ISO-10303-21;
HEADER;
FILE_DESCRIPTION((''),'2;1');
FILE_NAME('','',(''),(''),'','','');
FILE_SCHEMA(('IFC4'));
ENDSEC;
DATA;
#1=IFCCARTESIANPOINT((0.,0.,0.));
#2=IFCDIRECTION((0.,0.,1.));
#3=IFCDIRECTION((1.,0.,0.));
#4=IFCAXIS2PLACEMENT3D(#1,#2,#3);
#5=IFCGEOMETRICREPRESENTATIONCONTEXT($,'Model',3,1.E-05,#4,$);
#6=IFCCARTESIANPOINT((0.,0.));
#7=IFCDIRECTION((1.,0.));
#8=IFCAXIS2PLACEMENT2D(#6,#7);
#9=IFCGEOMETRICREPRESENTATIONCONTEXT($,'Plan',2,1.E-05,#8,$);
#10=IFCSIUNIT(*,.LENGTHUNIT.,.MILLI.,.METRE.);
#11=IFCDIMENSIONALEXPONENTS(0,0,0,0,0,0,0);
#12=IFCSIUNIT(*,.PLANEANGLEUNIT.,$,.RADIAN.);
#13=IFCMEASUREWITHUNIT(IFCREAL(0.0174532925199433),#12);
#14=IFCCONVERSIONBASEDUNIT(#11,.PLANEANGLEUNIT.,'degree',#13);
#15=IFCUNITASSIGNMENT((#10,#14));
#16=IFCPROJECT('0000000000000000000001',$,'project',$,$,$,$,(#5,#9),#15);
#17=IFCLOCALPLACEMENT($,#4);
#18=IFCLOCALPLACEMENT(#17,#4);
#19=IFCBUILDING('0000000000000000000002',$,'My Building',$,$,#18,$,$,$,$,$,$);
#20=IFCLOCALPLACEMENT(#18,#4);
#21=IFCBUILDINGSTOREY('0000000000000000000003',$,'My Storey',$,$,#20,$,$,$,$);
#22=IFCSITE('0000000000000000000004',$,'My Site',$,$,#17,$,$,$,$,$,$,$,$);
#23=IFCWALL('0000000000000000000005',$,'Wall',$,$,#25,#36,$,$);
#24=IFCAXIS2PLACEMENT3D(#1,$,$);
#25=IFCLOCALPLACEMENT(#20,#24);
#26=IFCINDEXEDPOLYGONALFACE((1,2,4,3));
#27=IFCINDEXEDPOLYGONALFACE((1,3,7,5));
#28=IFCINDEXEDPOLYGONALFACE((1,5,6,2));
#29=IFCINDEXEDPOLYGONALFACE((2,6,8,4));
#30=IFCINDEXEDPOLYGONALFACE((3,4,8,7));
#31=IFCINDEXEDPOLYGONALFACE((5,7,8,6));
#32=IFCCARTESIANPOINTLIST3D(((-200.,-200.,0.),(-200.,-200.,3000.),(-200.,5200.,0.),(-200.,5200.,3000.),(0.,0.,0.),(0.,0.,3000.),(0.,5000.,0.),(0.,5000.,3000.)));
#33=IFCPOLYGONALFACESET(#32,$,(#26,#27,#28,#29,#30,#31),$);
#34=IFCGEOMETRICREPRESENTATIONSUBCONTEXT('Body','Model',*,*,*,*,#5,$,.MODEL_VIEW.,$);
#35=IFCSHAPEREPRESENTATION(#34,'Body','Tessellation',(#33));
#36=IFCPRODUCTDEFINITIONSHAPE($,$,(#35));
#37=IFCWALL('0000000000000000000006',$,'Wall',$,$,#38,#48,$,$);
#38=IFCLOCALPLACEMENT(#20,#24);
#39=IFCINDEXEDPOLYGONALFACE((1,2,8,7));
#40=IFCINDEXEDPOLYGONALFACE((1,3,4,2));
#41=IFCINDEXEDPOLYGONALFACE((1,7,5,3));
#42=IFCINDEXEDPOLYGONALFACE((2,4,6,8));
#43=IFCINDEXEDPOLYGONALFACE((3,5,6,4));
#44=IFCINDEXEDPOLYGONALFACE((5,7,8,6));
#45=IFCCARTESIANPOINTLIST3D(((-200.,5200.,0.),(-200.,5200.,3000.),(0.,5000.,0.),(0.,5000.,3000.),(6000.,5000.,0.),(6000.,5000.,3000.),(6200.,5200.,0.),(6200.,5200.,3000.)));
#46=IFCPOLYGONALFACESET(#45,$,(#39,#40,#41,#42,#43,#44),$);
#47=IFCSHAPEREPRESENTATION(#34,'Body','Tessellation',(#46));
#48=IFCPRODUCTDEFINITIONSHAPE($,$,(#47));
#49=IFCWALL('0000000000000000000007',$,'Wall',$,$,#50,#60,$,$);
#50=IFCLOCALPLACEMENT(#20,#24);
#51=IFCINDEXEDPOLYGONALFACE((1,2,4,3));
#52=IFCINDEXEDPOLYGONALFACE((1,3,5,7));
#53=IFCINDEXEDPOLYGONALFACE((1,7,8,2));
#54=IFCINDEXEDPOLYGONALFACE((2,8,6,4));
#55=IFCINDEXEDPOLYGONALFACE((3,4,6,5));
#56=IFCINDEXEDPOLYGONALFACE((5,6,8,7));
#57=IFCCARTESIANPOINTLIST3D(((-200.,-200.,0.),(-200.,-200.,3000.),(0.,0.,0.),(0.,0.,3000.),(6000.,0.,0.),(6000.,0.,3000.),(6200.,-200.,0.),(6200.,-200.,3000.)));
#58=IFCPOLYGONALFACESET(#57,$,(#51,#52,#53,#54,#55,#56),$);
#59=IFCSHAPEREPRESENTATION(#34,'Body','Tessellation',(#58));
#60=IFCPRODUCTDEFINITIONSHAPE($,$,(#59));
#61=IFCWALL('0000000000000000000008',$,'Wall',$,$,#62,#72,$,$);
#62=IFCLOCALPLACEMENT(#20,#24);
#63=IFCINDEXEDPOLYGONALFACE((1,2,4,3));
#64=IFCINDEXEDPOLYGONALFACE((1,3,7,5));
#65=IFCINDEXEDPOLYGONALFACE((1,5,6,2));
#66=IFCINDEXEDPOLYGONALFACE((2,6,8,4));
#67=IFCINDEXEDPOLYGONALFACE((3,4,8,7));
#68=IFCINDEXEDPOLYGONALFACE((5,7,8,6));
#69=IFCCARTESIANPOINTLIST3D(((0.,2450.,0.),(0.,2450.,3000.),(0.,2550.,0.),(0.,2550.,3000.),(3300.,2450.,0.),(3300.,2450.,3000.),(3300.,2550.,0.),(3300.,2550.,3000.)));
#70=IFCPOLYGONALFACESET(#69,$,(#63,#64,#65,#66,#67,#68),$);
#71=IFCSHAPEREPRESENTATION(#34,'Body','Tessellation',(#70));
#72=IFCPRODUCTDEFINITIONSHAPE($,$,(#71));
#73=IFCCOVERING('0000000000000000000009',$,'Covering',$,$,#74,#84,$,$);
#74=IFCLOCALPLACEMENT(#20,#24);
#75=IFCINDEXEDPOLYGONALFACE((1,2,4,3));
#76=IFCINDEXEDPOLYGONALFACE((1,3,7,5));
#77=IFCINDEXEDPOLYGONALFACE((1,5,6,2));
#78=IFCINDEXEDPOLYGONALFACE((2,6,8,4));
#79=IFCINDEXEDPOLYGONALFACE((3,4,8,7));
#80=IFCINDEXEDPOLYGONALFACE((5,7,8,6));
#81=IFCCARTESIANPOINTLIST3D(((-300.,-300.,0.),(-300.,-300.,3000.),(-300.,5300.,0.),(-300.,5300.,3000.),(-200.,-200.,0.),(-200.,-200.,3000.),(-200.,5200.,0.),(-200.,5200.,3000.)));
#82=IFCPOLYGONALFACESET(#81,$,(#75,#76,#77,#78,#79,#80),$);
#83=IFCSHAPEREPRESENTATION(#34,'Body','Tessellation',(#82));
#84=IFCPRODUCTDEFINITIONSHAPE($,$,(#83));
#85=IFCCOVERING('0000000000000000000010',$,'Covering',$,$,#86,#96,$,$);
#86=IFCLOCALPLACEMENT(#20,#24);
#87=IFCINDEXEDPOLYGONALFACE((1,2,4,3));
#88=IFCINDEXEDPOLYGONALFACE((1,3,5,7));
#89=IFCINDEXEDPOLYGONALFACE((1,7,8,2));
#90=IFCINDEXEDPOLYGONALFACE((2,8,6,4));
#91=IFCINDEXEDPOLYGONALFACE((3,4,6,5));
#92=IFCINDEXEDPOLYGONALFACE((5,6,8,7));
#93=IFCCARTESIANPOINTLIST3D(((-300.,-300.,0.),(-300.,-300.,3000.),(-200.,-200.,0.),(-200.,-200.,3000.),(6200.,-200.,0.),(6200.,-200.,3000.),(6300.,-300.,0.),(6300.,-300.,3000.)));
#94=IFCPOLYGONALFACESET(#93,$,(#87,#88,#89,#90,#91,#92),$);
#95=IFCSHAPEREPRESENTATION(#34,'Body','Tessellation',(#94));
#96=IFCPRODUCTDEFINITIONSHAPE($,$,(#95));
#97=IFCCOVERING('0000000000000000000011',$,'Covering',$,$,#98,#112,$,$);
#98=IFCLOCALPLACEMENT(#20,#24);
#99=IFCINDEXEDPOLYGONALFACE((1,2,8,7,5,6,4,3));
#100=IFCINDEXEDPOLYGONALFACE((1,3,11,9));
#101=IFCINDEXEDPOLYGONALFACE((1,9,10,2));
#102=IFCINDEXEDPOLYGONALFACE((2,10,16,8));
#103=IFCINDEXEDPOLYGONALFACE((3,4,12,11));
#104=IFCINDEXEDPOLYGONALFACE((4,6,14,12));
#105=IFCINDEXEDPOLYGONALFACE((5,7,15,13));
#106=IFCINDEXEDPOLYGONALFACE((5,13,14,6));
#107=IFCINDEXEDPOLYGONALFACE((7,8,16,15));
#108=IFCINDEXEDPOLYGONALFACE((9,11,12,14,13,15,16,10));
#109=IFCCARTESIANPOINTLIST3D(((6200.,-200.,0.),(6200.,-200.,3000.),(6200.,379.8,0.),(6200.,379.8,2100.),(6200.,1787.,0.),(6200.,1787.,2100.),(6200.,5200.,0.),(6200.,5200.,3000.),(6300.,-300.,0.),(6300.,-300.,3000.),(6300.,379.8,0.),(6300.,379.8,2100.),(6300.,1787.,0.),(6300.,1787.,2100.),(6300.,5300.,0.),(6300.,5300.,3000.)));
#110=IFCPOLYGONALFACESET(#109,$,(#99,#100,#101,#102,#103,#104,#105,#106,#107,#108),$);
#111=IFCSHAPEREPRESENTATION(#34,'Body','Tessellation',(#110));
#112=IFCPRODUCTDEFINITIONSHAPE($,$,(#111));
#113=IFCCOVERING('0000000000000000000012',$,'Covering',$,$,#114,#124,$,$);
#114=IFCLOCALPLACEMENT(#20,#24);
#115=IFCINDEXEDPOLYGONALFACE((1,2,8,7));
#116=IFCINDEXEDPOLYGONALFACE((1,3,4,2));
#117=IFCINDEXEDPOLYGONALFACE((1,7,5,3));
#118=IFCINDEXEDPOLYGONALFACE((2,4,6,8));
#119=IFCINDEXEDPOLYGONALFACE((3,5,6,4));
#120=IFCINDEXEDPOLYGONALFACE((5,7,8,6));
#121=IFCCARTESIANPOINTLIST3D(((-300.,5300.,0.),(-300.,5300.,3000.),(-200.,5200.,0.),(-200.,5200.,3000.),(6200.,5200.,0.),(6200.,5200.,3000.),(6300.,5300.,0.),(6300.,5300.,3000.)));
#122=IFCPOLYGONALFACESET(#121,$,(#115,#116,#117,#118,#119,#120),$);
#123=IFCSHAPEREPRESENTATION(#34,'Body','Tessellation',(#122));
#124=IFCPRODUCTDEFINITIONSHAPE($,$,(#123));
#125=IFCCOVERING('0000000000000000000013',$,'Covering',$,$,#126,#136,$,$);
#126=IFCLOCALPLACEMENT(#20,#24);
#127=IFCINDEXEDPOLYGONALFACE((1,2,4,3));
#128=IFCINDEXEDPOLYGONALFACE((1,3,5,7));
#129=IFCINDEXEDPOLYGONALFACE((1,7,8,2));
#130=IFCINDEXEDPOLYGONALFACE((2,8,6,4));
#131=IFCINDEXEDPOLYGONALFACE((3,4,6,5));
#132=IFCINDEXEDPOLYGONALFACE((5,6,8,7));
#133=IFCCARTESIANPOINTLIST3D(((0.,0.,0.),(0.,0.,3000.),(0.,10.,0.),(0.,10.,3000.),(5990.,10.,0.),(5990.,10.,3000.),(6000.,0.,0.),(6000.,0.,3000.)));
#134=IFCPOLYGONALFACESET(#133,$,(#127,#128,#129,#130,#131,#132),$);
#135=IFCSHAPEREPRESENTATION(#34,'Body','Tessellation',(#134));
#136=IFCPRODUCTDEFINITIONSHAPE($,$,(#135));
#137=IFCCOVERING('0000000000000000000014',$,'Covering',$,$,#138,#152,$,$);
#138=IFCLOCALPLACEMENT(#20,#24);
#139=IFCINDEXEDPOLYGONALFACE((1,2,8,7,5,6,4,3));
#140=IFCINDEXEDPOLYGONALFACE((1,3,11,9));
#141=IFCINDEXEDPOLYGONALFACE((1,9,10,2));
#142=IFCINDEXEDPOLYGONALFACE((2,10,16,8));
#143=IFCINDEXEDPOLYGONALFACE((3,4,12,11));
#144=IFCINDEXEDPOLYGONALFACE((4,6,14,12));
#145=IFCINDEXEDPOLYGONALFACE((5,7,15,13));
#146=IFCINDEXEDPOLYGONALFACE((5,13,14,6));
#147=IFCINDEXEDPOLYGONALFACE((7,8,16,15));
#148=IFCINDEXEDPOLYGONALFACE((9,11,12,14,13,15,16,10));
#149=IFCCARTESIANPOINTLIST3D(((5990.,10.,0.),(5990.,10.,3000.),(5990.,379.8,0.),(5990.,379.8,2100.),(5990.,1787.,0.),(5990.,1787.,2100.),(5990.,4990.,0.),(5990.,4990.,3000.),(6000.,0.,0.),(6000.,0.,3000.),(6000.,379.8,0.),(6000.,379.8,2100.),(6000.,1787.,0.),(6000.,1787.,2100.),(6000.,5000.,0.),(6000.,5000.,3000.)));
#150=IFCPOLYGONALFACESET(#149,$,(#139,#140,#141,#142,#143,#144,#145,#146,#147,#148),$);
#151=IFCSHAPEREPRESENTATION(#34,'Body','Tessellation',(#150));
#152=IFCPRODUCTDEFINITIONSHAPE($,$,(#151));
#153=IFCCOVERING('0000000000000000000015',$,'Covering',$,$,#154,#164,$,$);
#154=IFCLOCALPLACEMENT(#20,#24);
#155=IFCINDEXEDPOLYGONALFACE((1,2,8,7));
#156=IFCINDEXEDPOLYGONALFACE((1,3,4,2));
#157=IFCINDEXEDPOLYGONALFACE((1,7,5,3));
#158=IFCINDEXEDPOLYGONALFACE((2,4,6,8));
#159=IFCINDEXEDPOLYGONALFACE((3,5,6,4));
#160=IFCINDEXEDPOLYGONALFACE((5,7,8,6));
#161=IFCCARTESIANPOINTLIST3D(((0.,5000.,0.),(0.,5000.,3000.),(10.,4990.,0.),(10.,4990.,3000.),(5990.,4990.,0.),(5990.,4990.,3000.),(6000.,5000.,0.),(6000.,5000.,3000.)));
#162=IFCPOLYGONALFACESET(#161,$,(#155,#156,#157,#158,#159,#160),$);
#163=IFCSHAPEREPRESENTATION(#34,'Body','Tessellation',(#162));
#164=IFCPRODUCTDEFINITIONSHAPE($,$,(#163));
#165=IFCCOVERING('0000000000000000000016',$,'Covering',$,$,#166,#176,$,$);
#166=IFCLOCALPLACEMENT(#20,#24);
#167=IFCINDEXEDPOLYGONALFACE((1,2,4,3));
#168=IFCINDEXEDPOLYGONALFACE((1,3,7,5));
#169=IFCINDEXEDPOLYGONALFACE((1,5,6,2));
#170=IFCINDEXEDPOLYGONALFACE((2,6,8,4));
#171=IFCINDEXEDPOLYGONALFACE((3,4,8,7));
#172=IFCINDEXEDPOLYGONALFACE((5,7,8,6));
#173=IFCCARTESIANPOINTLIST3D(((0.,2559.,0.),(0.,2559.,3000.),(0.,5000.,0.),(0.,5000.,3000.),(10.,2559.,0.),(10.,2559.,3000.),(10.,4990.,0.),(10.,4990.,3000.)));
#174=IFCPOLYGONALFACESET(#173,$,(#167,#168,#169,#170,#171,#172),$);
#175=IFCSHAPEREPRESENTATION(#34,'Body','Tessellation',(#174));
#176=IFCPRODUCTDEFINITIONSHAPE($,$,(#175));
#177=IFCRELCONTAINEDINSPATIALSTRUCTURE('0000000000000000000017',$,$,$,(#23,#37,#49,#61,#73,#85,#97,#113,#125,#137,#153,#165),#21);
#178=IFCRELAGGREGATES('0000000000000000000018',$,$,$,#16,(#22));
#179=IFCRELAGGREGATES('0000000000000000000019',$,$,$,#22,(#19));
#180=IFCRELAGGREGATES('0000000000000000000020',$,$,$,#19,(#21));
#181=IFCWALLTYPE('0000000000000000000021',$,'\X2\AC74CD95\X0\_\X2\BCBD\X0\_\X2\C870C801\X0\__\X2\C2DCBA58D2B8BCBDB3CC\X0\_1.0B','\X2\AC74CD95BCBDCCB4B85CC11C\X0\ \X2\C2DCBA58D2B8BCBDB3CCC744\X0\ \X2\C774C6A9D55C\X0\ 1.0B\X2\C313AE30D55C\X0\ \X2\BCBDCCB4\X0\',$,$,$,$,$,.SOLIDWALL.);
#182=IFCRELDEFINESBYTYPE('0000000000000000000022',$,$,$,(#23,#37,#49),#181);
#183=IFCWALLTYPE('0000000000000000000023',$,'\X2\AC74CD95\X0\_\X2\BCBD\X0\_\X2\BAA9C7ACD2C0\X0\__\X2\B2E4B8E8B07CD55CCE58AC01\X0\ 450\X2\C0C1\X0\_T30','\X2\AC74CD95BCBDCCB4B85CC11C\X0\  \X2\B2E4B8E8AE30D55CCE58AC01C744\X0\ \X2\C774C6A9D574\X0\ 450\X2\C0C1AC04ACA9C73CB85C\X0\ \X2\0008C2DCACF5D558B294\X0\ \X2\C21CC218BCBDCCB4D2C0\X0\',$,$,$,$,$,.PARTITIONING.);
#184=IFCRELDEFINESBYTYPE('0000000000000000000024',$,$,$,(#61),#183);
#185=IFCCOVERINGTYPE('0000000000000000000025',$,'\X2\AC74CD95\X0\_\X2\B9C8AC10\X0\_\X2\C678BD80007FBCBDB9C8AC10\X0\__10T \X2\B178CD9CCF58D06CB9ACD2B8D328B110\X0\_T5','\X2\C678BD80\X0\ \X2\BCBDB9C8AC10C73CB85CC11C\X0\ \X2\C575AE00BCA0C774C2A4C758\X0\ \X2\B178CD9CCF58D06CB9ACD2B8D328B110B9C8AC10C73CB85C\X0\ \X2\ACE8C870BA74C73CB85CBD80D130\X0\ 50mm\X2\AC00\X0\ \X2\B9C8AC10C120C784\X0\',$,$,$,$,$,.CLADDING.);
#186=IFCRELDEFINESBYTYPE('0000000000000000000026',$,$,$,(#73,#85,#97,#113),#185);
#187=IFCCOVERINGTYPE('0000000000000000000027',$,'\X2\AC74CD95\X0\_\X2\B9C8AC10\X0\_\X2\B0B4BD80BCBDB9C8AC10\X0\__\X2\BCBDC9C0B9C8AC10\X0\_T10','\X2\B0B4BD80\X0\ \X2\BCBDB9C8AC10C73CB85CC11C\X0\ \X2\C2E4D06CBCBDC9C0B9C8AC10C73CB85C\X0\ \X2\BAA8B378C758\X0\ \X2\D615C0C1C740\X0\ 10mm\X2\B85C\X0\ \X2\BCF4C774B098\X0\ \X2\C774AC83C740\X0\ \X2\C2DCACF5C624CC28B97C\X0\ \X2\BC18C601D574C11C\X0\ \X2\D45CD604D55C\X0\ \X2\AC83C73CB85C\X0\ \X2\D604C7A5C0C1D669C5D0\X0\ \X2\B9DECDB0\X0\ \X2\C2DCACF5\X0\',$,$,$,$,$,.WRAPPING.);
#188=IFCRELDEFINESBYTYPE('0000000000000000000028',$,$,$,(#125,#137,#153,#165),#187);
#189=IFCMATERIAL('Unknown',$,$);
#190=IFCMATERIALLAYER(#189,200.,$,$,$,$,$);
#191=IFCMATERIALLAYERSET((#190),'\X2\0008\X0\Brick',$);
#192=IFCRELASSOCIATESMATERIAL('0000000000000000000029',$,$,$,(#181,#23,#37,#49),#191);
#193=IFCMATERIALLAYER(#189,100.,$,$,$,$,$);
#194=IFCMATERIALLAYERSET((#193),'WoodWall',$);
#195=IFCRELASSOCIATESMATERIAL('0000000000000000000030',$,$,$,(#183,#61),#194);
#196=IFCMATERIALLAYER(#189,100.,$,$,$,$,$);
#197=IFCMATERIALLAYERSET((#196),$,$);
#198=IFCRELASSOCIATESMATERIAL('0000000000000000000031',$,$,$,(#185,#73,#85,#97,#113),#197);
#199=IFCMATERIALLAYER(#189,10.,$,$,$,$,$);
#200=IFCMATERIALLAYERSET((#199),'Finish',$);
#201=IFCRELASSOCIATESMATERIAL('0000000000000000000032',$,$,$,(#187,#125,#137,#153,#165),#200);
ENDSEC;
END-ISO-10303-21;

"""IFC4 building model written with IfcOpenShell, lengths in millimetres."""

from ifc_helpers import new_model, entity, si_unit, converted_unit, frame, origin_with_axes, origin_2d_with_axis, place, context, subcontext, project, spatial, line, indexed_curve, outline, extrude, material, layer, layer_set, layer_usage, type_object, element, save


model = new_model("IFC4")

# Units and contexts
model_context = context("Model", 3, precision=1e-05, world=origin_with_axes())
plan_context = context("Plan", 2, precision=1e-05, world=origin_2d_with_axis())
body_context = subcontext(model_context, "Body", "Model", "MODEL_VIEW")
ifc_project = project(units=[si_unit("LENGTHUNIT", "METRE", prefix="MILLI"), converted_unit("PLANEANGLEUNIT", "degree", entity("IfcReal", 0.0174532925199433), si_unit("PLANEANGLEUNIT", "RADIAN"), dimensions=[0, 0, 0, 0, 0, 0, 0])], contexts=[model_context, plan_context])

# Site, building, storey
site_placement = place(None, origin_with_axes())
site = spatial("IfcSite", under=ifc_project, at=site_placement, Name="My Site")
building_placement = place(site_placement, origin_with_axes())
building = spatial("IfcBuilding", under=site, at=building_placement, Name="My Building")
storey_placement = place(building_placement, origin_with_axes())
storey = spatial("IfcBuildingStorey", under=building, at=storey_placement, Name="My Storey")

# Walls
ifc_material = material(Name="Unknown")
ifc_layer_1 = layer(ifc_material, 200.0)
ifc_layer_set_1 = layer_set([ifc_layer_1], Name="\bBrick")
ifc_layer_usage_1 = layer_usage(ifc_layer_set_1, "AXIS2", "POSITIVE", 0.0)
wall_type_1 = type_object("IfcWallType", Name="건축_벽_조적__시멘트벽돌_1.0B", Description="건축벽체로서 시멘트벽돌을 이용한 1.0B쌓기한 벽체", PredefinedType="SOLIDWALL", material=ifc_layer_set_1)
wall_1_placement = place(storey_placement, frame((0.0, 0.0, 0.0), z_axis=(0.0, 0.0, 1.0), x_axis=(0.0, 1.0, 0.0)))
element("IfcWall", 1, at=wall_1_placement, inside=storey, type_object=wall_type_1, material=ifc_layer_usage_1, Name="Wall", context=body_context, shape_type="SweptSolid", body=[
    extrude(outline(indexed_curve([(0.0, 0.0), (-200.0, 200.0), (5200.0, 200.0), (5000.0, 0.0)], segments=[line(1, 2, 3, 4, 1)])), origin_with_axes(), (0.0, 0.0, 1.0), 3000.0),
])
ifc_layer_usage_2 = layer_usage(ifc_layer_set_1, "AXIS2", "POSITIVE", 0.0)
wall_2_placement = place(storey_placement, frame((0.0, 5000.0, 0.0), z_axis=(0.0, 0.0, 1.0), x_axis=(1.0, 0.0, 0.0)))
element("IfcWall", 2, at=wall_2_placement, inside=storey, type_object=wall_type_1, material=ifc_layer_usage_2, Name="Wall", context=body_context, shape_type="SweptSolid", body=[
    extrude(outline(indexed_curve([(0.0, 0.0), (-200.0, 200.0), (6200.0, 200.0), (6000.0, 0.0)], segments=[line(1, 2, 3, 4, 1)])), origin_with_axes(), (0.0, 0.0, 1.0), 3000.0),
])

# Walls
ifc_layer_usage_3 = layer_usage(ifc_layer_set_1, "AXIS2", "POSITIVE", 0.0)
wall_3_placement = place(storey_placement, frame((6000.0, 0.0, 0.0), z_axis=(0.0, 0.0, 1.0), x_axis=(-1.0, 0.0, 0.0)))
element("IfcWall", 3, at=wall_3_placement, inside=storey, type_object=wall_type_1, material=ifc_layer_usage_3, Name="Wall", context=body_context, shape_type="SweptSolid", body=[
    extrude(outline(indexed_curve([(0.0, 0.0), (-200.0, 200.0), (6200.0, 200.0), (6000.0, 0.0)], segments=[line(1, 2, 3, 4, 1)])), origin_with_axes(), (0.0, 0.0, 1.0), 3000.0),
])
ifc_layer_2 = layer(ifc_material, 100.0)
ifc_layer_set_2 = layer_set([ifc_layer_2], Name="WoodWall")
ifc_layer_usage_4 = layer_usage(ifc_layer_set_2, "AXIS2", "POSITIVE", 0.0)
wall_type_2 = type_object("IfcWallType", Name="건축_벽_목재틀__다루끼한치각 450상_T30", Description="건축벽체로서  다루기한치각을 이용해 450상간격으로 \b시공하는 순수벽체틀", PredefinedType="PARTITIONING", material=ifc_layer_set_2)
wall_4_placement = place(storey_placement, frame((0.0, 2450.0, 0.0), z_axis=(0.0, 0.0, 1.0), x_axis=(1.0, 0.0, 0.0)))
element("IfcWall", 4, at=wall_4_placement, inside=storey, type_object=wall_type_2, material=ifc_layer_usage_4, Name="Wall", context=body_context, shape_type="SweptSolid", body=[
    extrude(outline(indexed_curve([(0.0, 0.0), (0.0, 100.0), (3300.0, 100.0), (3300.0, 0.0)], segments=[line(1, 2, 3, 4, 1)])), origin_with_axes(), (0.0, 0.0, 1.0), 3000.0),
])

# Coverings
ifc_layer_3 = layer(ifc_material, 100.0)
ifc_layer_set_3 = layer_set([ifc_layer_3])
ifc_layer_usage_5 = layer_usage(ifc_layer_set_3, "AXIS2", "POSITIVE", 0.0)
covering_type_1 = type_object("IfcCoveringType", Name="건축_마감_외부\u007f벽마감__10T 노출콘크리트패널_T5", Description="외부 벽마감으로서 앵글베이스의 노출콘크리트패널마감으로 골조면으로부터 50mm가 마감선임", PredefinedType="CLADDING", material=ifc_layer_set_3)
covering_1_placement = place(storey_placement, frame((-200.0, -200.0, 0.0), z_axis=(0.0, 0.0, 1.0), x_axis=(0.0, 1.0, 0.0)))
element("IfcCovering", 5, at=covering_1_placement, inside=storey, type_object=covering_type_1, material=ifc_layer_usage_5, Name="Covering", context=body_context, shape_type="SweptSolid", body=[
    extrude(outline(indexed_curve([(0.0, 0.0), (-100.0, 100.0), (5500.0, 100.0), (5400.0, 0.0)], segments=[line(1, 2, 3, 4, 1)])), origin_with_axes(), (0.0, 0.0, 1.0), 3000.0),
])
ifc_layer_usage_6 = layer_usage(ifc_layer_set_3, "AXIS2", "NEGATIVE", 0.0)
covering_2_placement = place(storey_placement, frame((-200.0, -200.0, 0.0), z_axis=(0.0, 0.0, 1.0), x_axis=(1.0, 0.0, 0.0)))
element("IfcCovering", 6, at=covering_2_placement, inside=storey, type_object=covering_type_1, material=ifc_layer_usage_6, Name="Covering", context=body_context, shape_type="SweptSolid", body=[
    extrude(outline(indexed_curve([(-100.0, -100.0), (0.0, 0.0), (6400.0, 0.0), (6500.0, -100.0)], segments=[line(1, 2, 3, 4, 1)])), origin_with_axes(), (0.0, 0.0, 1.0), 3000.0),
])

# Covering, opening
ifc_layer_usage_7 = layer_usage(ifc_layer_set_3, "AXIS2", "NEGATIVE", 0.0)
covering_3_placement = place(storey_placement, frame((6200.0, -200.0, 0.0), z_axis=(0.0, 0.0, 1.0), x_axis=(0.0, 1.0, 0.0)))
covering_3 = element("IfcCovering", 7, at=covering_3_placement, inside=storey, type_object=covering_type_1, material=ifc_layer_usage_7, Name="Covering", context=body_context, shape_type="SweptSolid", body=[
    extrude(outline(indexed_curve([(-100.0, -100.0), (0.0, 0.0), (5400.0, 0.0), (5500.0, -100.0)], segments=[line(1, 2, 3, 4, 1)])), origin_with_axes(), (0.0, 0.0, 1.0), 3000.0),
])
opening_1_placement = place(covering_3_placement, frame((579.8, 200.0, 0.0), z_axis=(0.0, 0.0, 1.0), x_axis=(0.0, -1.0, 0.0)))
element("IfcOpeningElement", 8, at=opening_1_placement, cuts=covering_3, PredefinedType="OPENING", context=body_context, shape_type="SweptSolid", body=[
    extrude(outline(indexed_curve([(0.0, 0.0), (500.0, 0.0), (500.0, 1407.2), (0.0, 1407.2), (0.0, 0.0)])), frame((-122.9, 0.0, 0.0), z_axis=(0.0, 0.0, 1.0), x_axis=(1.0, 0.0, 0.0)), (0.0, 0.0, 1.0), 2100.0),
])

# Coverings
ifc_layer_usage_8 = layer_usage(ifc_layer_set_3, "AXIS2", "POSITIVE", 0.0)
covering_4_placement = place(storey_placement, frame((-200.0, 5200.0, 0.0), z_axis=(0.0, 0.0, 1.0), x_axis=(1.0, 0.0, 0.0)))
element("IfcCovering", 9, at=covering_4_placement, inside=storey, type_object=covering_type_1, material=ifc_layer_usage_8, Name="Covering", context=body_context, shape_type="SweptSolid", body=[
    extrude(outline(indexed_curve([(0.0, 0.0), (-100.0, 100.0), (6500.0, 100.0), (6400.0, 0.0)], segments=[line(1, 2, 3, 4, 1)])), origin_with_axes(), (0.0, 0.0, 1.0), 3000.0),
])
ifc_layer_4 = layer(ifc_material, 10.0)
ifc_layer_set_4 = layer_set([ifc_layer_4], Name="Finish")
ifc_layer_usage_9 = layer_usage(ifc_layer_set_4, "AXIS2", "POSITIVE", 0.0)
covering_type_2 = type_object("IfcCoveringType", Name="건축_마감_내부벽마감__벽지마감_T10", Description="내부 벽마감으로서 실크벽지마감으로 모델의 형상은 10mm로 보이나 이것은 시공오차를 반영해서 표현한 것으로 현장상황에 맞춰 시공", PredefinedType="WRAPPING", material=ifc_layer_set_4)
covering_5_placement = place(storey_placement, frame((6000.0, 10.0, 0.0), z_axis=(0.0, 0.0, 1.0), x_axis=(-1.0, 0.0, 0.0)))
element("IfcCovering", 10, at=covering_5_placement, inside=storey, type_object=covering_type_2, material=ifc_layer_usage_9, Name="Covering", context=body_context, shape_type="SweptSolid", body=[
    extrude(outline(indexed_curve([(10.0, 0.0), (0.0, 10.0), (6000.0, 10.0), (6000.0, 0.0)], segments=[line(1, 2, 3, 4, 1)])), origin_with_axes(), (0.0, 0.0, 1.0), 3000.0),
])

# Covering, opening
ifc_layer_usage_10 = layer_usage(ifc_layer_set_4, "AXIS2", "POSITIVE", 0.0)
covering_6_placement = place(storey_placement, frame((6000.0, 10.0, 0.0), z_axis=(0.0, 0.0, 1.0), x_axis=(0.0, 1.0, 0.0)))
covering_6 = element("IfcCovering", 11, at=covering_6_placement, inside=storey, type_object=covering_type_2, material=ifc_layer_usage_10, Name="Covering", context=body_context, shape_type="SweptSolid", body=[
    extrude(outline(indexed_curve([(-10.0, 0.0), (0.0, 10.0), (4980.0, 10.0), (4990.0, 0.0)], segments=[line(1, 2, 3, 4, 1)])), origin_with_axes(), (0.0, 0.0, 1.0), 3000.0),
])
opening_2_placement = place(covering_6_placement, frame((369.8, 308.4, 0.0), z_axis=(0.0, 0.0, 1.0), x_axis=(0.0, -1.0, 0.0)))
element("IfcOpeningElement", 12, at=opening_2_placement, cuts=covering_6, PredefinedType="OPENING", context=body_context, shape_type="SweptSolid", body=[
    extrude(outline(indexed_curve([(0.0, 0.0), (500.0, 0.0), (500.0, 1407.2), (0.0, 1407.2), (0.0, 0.0)])), frame((-122.9, 0.0, 0.0), z_axis=(0.0, 0.0, 1.0), x_axis=(1.0, 0.0, 0.0)), (0.0, 0.0, 1.0), 2100.0),
])

# Coverings
ifc_layer_usage_11 = layer_usage(ifc_layer_set_4, "AXIS2", "POSITIVE", 0.0)
covering_7_placement = place(storey_placement, frame((6000.0, 5000.0, 0.0), z_axis=(0.0, 0.0, 1.0), x_axis=(-1.0, 0.0, 0.0)))
element("IfcCovering", 13, at=covering_7_placement, inside=storey, type_object=covering_type_2, material=ifc_layer_usage_11, Name="Covering", context=body_context, shape_type="SweptSolid", body=[
    extrude(outline(indexed_curve([(0.0, 0.0), (10.0, 10.0), (5990.0, 10.0), (6000.0, 0.0)], segments=[line(1, 2, 3, 4, 1)])), origin_with_axes(), (0.0, 0.0, 1.0), 3000.0),
])
ifc_layer_usage_12 = layer_usage(ifc_layer_set_4, "AXIS2", "POSITIVE", 0.0)
covering_8_placement = place(storey_placement, frame((0.0, 5000.0, 0.0), z_axis=(0.0, 0.0, 1.0), x_axis=(0.0, -1.0, 0.0)))
element("IfcCovering", 14, at=covering_8_placement, inside=storey, type_object=covering_type_2, material=ifc_layer_usage_12, Name="Covering", context=body_context, shape_type="SweptSolid", body=[
    extrude(outline(indexed_curve([(0.0, 0.0), (10.0, 10.0), (2441.0, 10.0), (2441.0, 0.0)], segments=[line(1, 2, 3, 4, 1)])), origin_with_axes(), (0.0, 0.0, 1.0), 3000.0),
])

save(model, "model.ifc")
